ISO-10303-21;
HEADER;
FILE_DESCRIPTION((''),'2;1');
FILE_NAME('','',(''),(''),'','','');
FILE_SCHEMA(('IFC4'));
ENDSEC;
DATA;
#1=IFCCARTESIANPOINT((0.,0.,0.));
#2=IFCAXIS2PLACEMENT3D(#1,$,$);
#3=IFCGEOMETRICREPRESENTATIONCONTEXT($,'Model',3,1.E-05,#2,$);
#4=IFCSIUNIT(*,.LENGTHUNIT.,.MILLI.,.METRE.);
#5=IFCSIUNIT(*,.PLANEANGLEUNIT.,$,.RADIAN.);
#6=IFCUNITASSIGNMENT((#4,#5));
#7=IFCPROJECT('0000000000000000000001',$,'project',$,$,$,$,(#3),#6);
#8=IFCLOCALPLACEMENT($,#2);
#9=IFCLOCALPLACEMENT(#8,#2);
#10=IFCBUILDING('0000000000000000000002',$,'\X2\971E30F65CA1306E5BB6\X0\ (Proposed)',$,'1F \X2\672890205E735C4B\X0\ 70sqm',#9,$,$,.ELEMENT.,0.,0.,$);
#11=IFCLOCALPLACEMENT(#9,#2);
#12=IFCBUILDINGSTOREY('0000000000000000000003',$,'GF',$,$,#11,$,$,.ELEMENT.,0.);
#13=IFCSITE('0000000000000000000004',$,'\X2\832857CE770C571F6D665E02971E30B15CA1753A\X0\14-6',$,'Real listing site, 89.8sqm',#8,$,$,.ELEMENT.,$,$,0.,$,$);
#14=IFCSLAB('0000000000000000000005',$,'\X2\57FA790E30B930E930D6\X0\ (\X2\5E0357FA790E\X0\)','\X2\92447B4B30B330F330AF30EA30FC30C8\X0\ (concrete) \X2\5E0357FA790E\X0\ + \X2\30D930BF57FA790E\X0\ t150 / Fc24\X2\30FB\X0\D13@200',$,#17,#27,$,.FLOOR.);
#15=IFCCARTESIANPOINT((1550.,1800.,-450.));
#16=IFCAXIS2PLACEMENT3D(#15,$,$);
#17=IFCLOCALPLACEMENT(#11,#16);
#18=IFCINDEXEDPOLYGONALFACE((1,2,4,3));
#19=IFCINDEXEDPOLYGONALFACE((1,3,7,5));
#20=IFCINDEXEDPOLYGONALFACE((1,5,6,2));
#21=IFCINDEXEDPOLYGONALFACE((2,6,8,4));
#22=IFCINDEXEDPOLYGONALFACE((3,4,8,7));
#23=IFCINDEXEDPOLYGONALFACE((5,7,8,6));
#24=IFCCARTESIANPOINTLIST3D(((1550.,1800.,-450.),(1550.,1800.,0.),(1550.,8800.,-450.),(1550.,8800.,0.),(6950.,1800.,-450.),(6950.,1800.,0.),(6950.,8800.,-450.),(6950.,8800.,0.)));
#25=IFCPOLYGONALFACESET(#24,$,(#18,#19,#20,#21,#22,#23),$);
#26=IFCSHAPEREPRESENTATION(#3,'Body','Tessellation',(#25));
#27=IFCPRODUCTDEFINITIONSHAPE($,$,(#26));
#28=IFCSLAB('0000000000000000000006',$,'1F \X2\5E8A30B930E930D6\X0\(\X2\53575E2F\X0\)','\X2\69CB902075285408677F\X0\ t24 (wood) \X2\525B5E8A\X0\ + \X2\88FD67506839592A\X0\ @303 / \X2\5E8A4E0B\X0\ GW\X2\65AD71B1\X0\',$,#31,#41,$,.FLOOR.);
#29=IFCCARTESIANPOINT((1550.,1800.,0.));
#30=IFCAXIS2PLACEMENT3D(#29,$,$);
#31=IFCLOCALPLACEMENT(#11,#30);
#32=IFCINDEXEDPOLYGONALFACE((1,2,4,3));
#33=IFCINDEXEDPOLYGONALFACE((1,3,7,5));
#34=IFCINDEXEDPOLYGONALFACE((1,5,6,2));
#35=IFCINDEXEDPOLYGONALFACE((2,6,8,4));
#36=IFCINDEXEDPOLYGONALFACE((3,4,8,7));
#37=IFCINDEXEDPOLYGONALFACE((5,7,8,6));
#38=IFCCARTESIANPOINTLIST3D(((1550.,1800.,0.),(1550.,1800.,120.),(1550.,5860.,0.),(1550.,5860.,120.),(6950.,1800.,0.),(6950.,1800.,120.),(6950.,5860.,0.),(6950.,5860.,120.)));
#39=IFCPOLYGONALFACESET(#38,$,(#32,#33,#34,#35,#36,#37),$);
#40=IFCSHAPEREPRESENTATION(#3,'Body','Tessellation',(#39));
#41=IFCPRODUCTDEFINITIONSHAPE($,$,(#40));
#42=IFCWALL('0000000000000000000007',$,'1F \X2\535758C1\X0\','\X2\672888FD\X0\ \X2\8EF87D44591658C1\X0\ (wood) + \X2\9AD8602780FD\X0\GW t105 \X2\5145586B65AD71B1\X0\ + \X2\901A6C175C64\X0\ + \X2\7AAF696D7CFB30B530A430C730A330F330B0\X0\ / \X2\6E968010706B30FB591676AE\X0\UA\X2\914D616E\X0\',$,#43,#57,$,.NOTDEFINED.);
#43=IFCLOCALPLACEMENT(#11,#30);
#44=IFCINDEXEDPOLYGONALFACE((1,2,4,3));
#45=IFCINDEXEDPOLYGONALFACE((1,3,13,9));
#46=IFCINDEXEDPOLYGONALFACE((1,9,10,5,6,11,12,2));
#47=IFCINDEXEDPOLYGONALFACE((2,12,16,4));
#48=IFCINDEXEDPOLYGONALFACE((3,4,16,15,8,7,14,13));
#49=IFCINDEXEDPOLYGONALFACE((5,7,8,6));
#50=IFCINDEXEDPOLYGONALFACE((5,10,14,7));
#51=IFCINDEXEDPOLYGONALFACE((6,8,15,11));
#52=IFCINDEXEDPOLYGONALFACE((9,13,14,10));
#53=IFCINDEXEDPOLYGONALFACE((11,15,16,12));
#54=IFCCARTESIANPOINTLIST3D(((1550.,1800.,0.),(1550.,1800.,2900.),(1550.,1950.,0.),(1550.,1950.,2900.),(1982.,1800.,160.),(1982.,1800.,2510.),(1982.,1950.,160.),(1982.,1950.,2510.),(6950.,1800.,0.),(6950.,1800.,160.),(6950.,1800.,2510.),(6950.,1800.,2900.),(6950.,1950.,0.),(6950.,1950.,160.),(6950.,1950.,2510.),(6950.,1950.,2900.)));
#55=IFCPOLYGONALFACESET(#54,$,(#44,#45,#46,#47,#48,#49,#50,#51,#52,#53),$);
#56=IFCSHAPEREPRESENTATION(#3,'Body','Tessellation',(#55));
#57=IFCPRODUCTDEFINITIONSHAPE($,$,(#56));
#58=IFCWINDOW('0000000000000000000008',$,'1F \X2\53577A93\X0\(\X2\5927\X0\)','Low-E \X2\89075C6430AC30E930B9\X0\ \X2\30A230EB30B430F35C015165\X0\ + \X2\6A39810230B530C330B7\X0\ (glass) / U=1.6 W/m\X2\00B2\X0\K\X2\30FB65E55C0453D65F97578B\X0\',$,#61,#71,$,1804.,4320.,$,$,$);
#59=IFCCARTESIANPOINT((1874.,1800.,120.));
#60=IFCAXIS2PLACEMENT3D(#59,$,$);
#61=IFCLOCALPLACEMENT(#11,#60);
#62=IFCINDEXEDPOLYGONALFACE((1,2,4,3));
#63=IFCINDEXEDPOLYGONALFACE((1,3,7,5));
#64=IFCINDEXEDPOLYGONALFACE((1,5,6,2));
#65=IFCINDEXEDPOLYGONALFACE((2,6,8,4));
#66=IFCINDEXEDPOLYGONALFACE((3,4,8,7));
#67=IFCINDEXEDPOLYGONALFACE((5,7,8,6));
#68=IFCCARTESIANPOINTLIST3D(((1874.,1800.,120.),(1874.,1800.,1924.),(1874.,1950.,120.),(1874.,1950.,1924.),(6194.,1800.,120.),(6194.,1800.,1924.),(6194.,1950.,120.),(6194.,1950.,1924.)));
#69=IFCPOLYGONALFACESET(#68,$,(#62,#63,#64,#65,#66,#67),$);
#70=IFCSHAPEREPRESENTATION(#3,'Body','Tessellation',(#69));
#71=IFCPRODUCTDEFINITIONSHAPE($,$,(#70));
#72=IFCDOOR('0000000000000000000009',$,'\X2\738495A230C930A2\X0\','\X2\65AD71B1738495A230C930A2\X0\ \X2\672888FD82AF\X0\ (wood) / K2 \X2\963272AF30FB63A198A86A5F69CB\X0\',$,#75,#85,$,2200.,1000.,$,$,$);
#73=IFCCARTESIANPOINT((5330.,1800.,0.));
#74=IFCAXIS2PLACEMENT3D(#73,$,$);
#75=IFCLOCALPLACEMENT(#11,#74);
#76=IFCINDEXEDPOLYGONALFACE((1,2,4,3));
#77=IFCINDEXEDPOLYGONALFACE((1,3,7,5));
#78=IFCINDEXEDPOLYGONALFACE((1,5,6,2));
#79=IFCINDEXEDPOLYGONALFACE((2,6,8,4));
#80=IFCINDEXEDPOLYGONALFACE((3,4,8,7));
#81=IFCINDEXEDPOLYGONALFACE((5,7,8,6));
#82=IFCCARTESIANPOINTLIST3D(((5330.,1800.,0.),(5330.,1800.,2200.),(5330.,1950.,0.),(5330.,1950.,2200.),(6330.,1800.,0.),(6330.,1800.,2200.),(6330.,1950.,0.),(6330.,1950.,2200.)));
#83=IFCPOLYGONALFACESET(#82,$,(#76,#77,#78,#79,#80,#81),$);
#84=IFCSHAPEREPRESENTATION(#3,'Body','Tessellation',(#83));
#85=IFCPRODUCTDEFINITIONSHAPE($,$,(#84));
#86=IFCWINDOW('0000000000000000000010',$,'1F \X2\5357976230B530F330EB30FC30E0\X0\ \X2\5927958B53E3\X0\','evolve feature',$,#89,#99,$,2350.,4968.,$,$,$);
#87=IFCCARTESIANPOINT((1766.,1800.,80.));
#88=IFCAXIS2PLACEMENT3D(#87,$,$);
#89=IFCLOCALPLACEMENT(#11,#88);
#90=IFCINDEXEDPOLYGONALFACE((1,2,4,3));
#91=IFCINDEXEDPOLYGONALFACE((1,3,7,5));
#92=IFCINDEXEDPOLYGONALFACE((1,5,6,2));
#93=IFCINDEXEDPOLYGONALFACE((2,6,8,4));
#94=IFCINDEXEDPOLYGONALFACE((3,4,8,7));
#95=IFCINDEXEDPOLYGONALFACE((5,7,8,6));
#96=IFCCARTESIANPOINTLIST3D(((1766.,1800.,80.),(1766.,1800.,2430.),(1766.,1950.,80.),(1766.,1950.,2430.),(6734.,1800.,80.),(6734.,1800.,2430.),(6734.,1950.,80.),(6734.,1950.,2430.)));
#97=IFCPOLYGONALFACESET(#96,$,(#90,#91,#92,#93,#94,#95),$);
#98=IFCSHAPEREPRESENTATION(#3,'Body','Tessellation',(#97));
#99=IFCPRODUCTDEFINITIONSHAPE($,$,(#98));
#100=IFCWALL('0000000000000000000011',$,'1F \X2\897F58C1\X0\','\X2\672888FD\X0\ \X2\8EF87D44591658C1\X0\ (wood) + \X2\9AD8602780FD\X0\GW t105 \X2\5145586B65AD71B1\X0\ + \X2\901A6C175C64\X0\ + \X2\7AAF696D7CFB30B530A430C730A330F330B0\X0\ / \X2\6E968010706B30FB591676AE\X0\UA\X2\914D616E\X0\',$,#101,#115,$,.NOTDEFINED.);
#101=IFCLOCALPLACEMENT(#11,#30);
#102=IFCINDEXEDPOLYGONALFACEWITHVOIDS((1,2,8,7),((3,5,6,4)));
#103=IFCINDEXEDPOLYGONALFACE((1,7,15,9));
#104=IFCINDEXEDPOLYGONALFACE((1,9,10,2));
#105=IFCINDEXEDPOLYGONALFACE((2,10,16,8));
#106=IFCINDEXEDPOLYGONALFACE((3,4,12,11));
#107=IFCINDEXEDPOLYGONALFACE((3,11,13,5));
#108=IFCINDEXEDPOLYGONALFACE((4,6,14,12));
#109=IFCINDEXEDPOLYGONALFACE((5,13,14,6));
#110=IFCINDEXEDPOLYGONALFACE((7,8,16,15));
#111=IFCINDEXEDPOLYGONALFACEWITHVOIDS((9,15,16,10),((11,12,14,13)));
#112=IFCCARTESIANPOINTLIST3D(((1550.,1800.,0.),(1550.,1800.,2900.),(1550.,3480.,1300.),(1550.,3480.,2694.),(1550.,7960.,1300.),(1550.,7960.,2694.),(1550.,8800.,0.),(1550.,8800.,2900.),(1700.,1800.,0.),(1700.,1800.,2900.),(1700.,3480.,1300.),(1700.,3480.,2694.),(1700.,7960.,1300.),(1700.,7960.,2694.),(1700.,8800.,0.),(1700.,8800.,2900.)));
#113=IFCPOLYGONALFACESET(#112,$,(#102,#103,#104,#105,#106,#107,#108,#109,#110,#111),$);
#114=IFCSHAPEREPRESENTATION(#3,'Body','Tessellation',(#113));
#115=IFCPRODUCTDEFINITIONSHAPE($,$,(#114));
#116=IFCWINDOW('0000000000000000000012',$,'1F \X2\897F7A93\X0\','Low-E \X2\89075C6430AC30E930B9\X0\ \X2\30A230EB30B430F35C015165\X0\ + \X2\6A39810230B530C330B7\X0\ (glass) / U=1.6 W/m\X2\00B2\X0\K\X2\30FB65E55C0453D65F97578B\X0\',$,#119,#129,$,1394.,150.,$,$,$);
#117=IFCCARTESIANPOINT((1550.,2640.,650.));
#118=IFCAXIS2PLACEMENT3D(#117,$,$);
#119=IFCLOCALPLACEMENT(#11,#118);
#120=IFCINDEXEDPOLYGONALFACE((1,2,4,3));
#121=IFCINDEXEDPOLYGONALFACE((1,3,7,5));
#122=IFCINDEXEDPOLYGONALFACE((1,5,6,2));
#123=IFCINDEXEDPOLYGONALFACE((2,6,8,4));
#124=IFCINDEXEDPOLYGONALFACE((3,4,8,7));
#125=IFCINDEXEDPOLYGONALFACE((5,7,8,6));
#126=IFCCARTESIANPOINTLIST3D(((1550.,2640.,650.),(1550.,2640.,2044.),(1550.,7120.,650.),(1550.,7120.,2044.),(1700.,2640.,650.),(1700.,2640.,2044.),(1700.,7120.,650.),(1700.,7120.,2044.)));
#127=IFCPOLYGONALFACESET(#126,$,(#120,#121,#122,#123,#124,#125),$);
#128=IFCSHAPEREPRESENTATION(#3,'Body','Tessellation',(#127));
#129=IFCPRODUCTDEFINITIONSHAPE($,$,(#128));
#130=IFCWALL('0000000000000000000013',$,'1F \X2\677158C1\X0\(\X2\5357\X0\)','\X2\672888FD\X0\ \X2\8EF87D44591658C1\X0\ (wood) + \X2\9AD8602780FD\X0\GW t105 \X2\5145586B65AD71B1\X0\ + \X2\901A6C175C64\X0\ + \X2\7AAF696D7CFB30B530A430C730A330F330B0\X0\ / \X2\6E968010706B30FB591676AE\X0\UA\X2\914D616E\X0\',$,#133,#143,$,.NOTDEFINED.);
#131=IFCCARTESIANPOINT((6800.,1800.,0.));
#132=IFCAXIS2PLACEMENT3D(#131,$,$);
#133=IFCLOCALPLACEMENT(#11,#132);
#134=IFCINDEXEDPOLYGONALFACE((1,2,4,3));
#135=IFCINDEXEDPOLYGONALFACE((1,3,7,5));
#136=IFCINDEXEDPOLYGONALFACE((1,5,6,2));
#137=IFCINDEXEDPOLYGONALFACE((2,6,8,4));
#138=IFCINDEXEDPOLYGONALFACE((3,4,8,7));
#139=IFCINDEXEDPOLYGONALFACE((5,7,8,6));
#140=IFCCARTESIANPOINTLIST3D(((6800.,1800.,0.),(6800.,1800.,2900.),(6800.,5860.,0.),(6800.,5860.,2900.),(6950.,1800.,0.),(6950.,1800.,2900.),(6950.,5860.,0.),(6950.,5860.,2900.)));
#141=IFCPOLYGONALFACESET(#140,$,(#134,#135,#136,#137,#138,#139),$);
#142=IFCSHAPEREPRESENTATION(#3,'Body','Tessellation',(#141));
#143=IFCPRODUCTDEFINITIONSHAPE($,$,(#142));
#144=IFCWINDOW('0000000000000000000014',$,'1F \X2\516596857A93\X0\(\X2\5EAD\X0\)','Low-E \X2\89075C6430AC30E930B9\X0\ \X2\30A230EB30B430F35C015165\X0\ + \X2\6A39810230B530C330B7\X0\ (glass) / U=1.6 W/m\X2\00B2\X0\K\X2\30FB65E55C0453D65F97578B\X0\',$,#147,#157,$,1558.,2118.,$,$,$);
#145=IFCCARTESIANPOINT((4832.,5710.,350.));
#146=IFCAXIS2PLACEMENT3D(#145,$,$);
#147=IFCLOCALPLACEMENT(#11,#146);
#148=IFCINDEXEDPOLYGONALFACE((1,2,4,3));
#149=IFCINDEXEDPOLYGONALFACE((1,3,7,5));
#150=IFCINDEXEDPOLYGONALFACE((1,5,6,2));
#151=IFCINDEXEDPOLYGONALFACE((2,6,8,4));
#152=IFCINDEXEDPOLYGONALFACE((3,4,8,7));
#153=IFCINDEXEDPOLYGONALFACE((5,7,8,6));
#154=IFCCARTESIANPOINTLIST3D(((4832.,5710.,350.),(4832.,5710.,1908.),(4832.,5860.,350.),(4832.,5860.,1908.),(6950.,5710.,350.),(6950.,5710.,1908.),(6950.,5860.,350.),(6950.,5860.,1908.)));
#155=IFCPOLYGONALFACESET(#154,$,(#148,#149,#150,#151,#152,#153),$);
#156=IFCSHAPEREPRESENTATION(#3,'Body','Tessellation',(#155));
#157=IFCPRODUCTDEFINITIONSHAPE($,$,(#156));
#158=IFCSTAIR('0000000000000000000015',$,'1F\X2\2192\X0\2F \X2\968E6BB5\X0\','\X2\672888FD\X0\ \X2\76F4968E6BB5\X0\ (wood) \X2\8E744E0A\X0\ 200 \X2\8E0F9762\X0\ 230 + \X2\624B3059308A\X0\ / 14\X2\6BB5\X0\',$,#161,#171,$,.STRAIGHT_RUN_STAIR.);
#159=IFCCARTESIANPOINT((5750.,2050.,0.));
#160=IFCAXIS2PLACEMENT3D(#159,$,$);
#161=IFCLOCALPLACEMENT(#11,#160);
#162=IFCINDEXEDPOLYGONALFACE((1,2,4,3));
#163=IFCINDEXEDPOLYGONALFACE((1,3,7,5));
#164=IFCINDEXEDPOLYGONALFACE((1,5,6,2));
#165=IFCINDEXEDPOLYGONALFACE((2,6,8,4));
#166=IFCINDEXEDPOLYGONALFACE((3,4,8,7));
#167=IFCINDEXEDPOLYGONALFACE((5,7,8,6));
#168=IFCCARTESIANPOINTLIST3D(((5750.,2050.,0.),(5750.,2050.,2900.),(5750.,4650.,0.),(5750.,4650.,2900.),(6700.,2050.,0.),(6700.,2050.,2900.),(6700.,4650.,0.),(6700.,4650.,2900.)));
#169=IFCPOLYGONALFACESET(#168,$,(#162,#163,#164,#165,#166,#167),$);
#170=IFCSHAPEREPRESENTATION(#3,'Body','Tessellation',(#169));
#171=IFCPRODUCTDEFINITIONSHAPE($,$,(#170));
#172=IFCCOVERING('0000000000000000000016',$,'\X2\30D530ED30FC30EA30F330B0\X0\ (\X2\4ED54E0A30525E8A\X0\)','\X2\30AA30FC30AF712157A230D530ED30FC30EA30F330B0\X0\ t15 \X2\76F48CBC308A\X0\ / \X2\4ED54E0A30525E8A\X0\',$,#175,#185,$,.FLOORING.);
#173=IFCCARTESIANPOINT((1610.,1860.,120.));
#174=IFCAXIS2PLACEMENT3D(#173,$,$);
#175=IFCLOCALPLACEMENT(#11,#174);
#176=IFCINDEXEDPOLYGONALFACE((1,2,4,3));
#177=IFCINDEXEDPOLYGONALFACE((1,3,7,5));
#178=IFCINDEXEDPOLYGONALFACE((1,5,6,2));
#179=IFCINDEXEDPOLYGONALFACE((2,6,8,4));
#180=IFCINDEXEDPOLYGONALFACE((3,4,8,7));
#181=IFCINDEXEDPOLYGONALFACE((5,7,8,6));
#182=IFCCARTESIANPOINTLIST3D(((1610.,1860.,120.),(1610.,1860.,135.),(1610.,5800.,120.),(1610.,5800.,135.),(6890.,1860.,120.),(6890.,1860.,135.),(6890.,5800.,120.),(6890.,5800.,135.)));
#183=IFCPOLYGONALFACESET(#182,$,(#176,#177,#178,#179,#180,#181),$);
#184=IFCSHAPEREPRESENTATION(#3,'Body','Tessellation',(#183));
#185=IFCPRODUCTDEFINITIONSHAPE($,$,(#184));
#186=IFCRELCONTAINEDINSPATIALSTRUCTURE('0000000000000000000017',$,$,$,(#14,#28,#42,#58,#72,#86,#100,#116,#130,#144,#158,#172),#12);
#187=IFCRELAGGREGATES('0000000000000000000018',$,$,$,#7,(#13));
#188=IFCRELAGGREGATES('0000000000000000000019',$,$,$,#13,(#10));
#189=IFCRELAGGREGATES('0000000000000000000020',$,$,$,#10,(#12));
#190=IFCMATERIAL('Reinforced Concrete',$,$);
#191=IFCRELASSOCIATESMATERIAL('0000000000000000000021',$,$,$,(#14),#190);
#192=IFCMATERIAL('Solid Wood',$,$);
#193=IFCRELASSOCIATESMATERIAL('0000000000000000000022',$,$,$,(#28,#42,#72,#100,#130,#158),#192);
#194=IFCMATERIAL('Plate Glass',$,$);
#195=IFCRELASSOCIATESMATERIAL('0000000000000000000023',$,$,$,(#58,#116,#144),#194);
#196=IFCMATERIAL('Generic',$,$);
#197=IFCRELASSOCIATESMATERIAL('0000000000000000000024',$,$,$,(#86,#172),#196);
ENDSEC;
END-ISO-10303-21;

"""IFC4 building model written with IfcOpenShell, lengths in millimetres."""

from ifc_helpers import new_model, si_unit, frame, frame_2d, origin, place, context, project, spatial, rectangle, extrude, material, element, fill, save


model = new_model("IFC4")

# Units and contexts
model_context = context("Model", 3, precision=1e-05, world=origin())
ifc_project = project(units=[si_unit("LENGTHUNIT", "METRE", prefix="MILLI"), si_unit("PLANEANGLEUNIT", "RADIAN")], contexts=[model_context])

# Site, building, storey
site_placement = place(None, origin())
site = spatial("IfcSite", under=ifc_project, at=site_placement, Name="茨城県土浦市霞ケ岡町14-6", ObjectType="Real listing site, 89.8sqm", CompositionType="ELEMENT", RefElevation=0.0)
building_placement = place(site_placement, origin())
building = spatial("IfcBuilding", under=site, at=building_placement, Name="霞ヶ岡の家 (Proposed)", ObjectType="1F 木造平屋 70sqm", CompositionType="ELEMENT", ElevationOfRefHeight=0.0, ElevationOfTerrain=0.0)
storey_placement = place(building_placement, origin())
storey = spatial("IfcBuildingStorey", under=building, at=storey_placement, Name="GF", CompositionType="ELEMENT", Elevation=0.0)

# Slabs
ifc_material_1 = material(Name="Reinforced Concrete")
slab_1_placement = place(storey_placement, frame((1550.0, 1800.0, -450.0)))
element("IfcSlab", 1, at=slab_1_placement, inside=storey, material=ifc_material_1, Name="基礎スラブ (布基礎)", Description="鉄筋コンクリート (concrete) 布基礎 + ベタ基礎 t150 / Fc24・D13@200", PredefinedType="FLOOR", context=model_context, shape_type="SweptSolid", body=[
    extrude(rectangle(XDim=5400.0, YDim=7000.0, at=frame_2d((2700.0, 3500.0))), frame((1550.0, 1800.0, -450.0)), (0.0, 0.0, 1.0), 450.0),
])
ifc_material_2 = material(Name="Solid Wood")
slab_2_placement = place(storey_placement, frame((1550.0, 1800.0, 0.0)))
element("IfcSlab", 2, at=slab_2_placement, inside=storey, material=ifc_material_2, Name="1F 床スラブ(南帯)", Description="構造用合板 t24 (wood) 剛床 + 製材根太 @303 / 床下 GW断熱", PredefinedType="FLOOR", context=model_context, shape_type="SweptSolid", body=[
    extrude(rectangle(XDim=5400.0, YDim=4060.0, at=frame_2d((2700.0, 2030.0))), frame((1550.0, 1800.0, 0.0)), (0.0, 0.0, 1.0), 120.0),
])

# Wall, openings, windows, door
wall_1_placement = place(storey_placement, frame((1550.0, 1800.0, 0.0)))
wall_1 = element("IfcWall", 3, at=wall_1_placement, inside=storey, material=ifc_material_2, Name="1F 南壁", Description="木製 軸組外壁 (wood) + 高性能GW t105 充填断熱 + 通気層 + 窯業系サイディング / 準耐火・外皮UA配慮", PredefinedType="NOTDEFINED", context=model_context, shape_type="SweptSolid", body=[
    extrude(rectangle(XDim=5400.0, YDim=150.0, at=frame_2d((2700.0, 75.0))), frame((1550.0, 1800.0, 0.0)), (0.0, 0.0, 1.0), 2900.0),
])
opening_1_placement = place(storey_placement, frame((1874.0, 1800.0, 120.0)))
opening_1 = element("IfcOpeningElement", 4, at=opening_1_placement, cuts=wall_1, PredefinedType="NOTDEFINED", context=model_context, shape_type="SweptSolid", body=[
    extrude(rectangle(XDim=4320.0, YDim=150.0, at=frame_2d((2160.0, 75.0))), frame((1874.0, 1800.0, 120.0)), (0.0, 0.0, 1.0), 1804.0),
])
opening_2_placement = place(storey_placement, frame((5330.0, 1800.0, 0.0)))
opening_2 = element("IfcOpeningElement", 5, at=opening_2_placement, cuts=wall_1, PredefinedType="NOTDEFINED", context=model_context, shape_type="SweptSolid", body=[
    extrude(rectangle(XDim=1000.0, YDim=150.0, at=frame_2d((500.0, 75.0))), frame((5330.0, 1800.0, 0.0)), (0.0, 0.0, 1.0), 2200.0),
])
opening_3_placement = place(storey_placement, frame((1766.0, 1800.0, 80.0)))
opening_3 = element("IfcOpeningElement", 6, at=opening_3_placement, cuts=wall_1, PredefinedType="NOTDEFINED", context=model_context, shape_type="SweptSolid", body=[
    extrude(rectangle(XDim=4968.0, YDim=150.0, at=frame_2d((2484.0, 75.0))), frame((1766.0, 1800.0, 80.0)), (0.0, 0.0, 1.0), 2350.0),
])
ifc_material_3 = material(Name="Plate Glass")
window_1_placement = place(storey_placement, frame((1874.0, 1800.0, 120.0)))
window_1 = element("IfcWindow", 7, at=window_1_placement, inside=storey, material=ifc_material_3, Name="1F 南窓(大)", Description="Low-E 複層ガラス アルゴン封入 + 樹脂サッシ (glass) / U=1.6 W/m²K・日射取得型", OverallHeight=1804.0, OverallWidth=4320.0, context=model_context, shape_type="SweptSolid", body=[
    extrude(rectangle(XDim=4320.0, YDim=150.0, at=frame_2d((2160.0, 75.0))), frame((1874.0, 1800.0, 120.0)), (0.0, 0.0, 1.0), 1804.0),
])
fill(opening_1, window_1)
door_1_placement = place(storey_placement, frame((5330.0, 1800.0, 0.0)))
door_1 = element("IfcDoor", 8, at=door_1_placement, inside=storey, material=ifc_material_2, Name="玄関ドア", Description="断熱玄関ドア 木製芯 (wood) / K2 防犯・採風機構", OverallHeight=2200.0, OverallWidth=1000.0, context=model_context, shape_type="SweptSolid", body=[
    extrude(rectangle(XDim=1000.0, YDim=150.0, at=frame_2d((500.0, 75.0))), frame((5330.0, 1800.0, 0.0)), (0.0, 0.0, 1.0), 2200.0),
])
fill(opening_2, door_1)
ifc_material_4 = material(Name="Generic")
window_2_placement = place(storey_placement, frame((1766.0, 1800.0, 80.0)))
window_2 = element("IfcWindow", 9, at=window_2_placement, inside=storey, material=ifc_material_4, Name="1F 南面サンルーム 大開口", Description="evolve feature", OverallHeight=2350.0, OverallWidth=4968.0, context=model_context, shape_type="SweptSolid", body=[
    extrude(rectangle(XDim=4968.0, YDim=150.0, at=frame_2d((2484.0, 75.0))), frame((1766.0, 1800.0, 80.0)), (0.0, 0.0, 1.0), 2350.0),
])
fill(opening_3, window_2)

# Walls, openings, windows
wall_2_placement = place(storey_placement, frame((1550.0, 1800.0, 0.0)))
wall_2 = element("IfcWall", 10, at=wall_2_placement, inside=storey, material=ifc_material_2, Name="1F 西壁", Description="木製 軸組外壁 (wood) + 高性能GW t105 充填断熱 + 通気層 + 窯業系サイディング / 準耐火・外皮UA配慮", PredefinedType="NOTDEFINED", context=model_context, shape_type="SweptSolid", body=[
    extrude(rectangle(XDim=150.0, YDim=7000.0, at=frame_2d((75.0, 3500.0))), frame((1550.0, 1800.0, 0.0)), (0.0, 0.0, 1.0), 2900.0),
])
opening_4_placement = place(storey_placement, frame((1550.0, 2640.0, 650.0)))
opening_4 = element("IfcOpeningElement", 11, at=opening_4_placement, cuts=wall_2, PredefinedType="NOTDEFINED", context=model_context, shape_type="SweptSolid", body=[
    extrude(rectangle(XDim=150.0, YDim=4480.0, at=frame_2d((75.0, 2240.0))), frame((1550.0, 2640.0, 650.0)), (0.0, 0.0, 1.0), 1394.0),
])
window_3_placement = place(storey_placement, frame((1550.0, 2640.0, 650.0)))
window_3 = element("IfcWindow", 12, at=window_3_placement, inside=storey, material=ifc_material_3, Name="1F 西窓", Description="Low-E 複層ガラス アルゴン封入 + 樹脂サッシ (glass) / U=1.6 W/m²K・日射取得型", OverallHeight=1394.0, OverallWidth=150.0, context=model_context, shape_type="SweptSolid", body=[
    extrude(rectangle(XDim=150.0, YDim=4480.0, at=frame_2d((75.0, 2240.0))), frame((1550.0, 2640.0, 650.0)), (0.0, 0.0, 1.0), 1394.0),
])
fill(opening_4, window_3)
wall_3_placement = place(storey_placement, frame((6800.0, 1800.0, 0.0)))
wall_3 = element("IfcWall", 13, at=wall_3_placement, inside=storey, material=ifc_material_2, Name="1F 東壁(南)", Description="木製 軸組外壁 (wood) + 高性能GW t105 充填断熱 + 通気層 + 窯業系サイディング / 準耐火・外皮UA配慮", PredefinedType="NOTDEFINED", context=model_context, shape_type="SweptSolid", body=[
    extrude(rectangle(XDim=150.0, YDim=4060.0, at=frame_2d((75.0, 2030.0))), frame((6800.0, 1800.0, 0.0)), (0.0, 0.0, 1.0), 2900.0),
])
opening_5_placement = place(storey_placement, frame((4832.0, 5710.0, 350.0)))
opening_5 = element("IfcOpeningElement", 14, at=opening_5_placement, cuts=wall_3, PredefinedType="NOTDEFINED", context=model_context, shape_type="SweptSolid", body=[
    extrude(rectangle(XDim=2118.0, YDim=150.0, at=frame_2d((1059.0, 75.0))), frame((4832.0, 5710.0, 350.0)), (0.0, 0.0, 1.0), 1558.0),
])
window_4_placement = place(storey_placement, frame((4832.0, 5710.0, 350.0)))
window_4 = element("IfcWindow", 15, at=window_4_placement, inside=storey, material=ifc_material_3, Name="1F 入隅窓(庭)", Description="Low-E 複層ガラス アルゴン封入 + 樹脂サッシ (glass) / U=1.6 W/m²K・日射取得型", OverallHeight=1558.0, OverallWidth=2118.0, context=model_context, shape_type="SweptSolid", body=[
    extrude(rectangle(XDim=2118.0, YDim=150.0, at=frame_2d((1059.0, 75.0))), frame((4832.0, 5710.0, 350.0)), (0.0, 0.0, 1.0), 1558.0),
])
fill(opening_5, window_4)

# Stair
stair_placement = place(storey_placement, frame((5750.0, 2050.0, 0.0)))
element("IfcStair", 16, at=stair_placement, inside=storey, material=ifc_material_2, Name="1F→2F 階段", Description="木製 直階段 (wood) 蹴上 200 踏面 230 + 手すり / 14段", PredefinedType="STRAIGHT_RUN_STAIR", context=model_context, shape_type="SweptSolid", body=[
    extrude(rectangle(XDim=950.0, YDim=2600.0, at=frame_2d((475.0, 1300.0))), frame((5750.0, 2050.0, 0.0)), (0.0, 0.0, 1.0), 2900.0),
])

# Covering
covering_placement = place(storey_placement, frame((1610.0, 1860.0, 120.0)))
element("IfcCovering", 17, at=covering_placement, inside=storey, material=ifc_material_4, Name="フローリング (仕上げ床)", Description="オーク無垢フローリング t15 直貼り / 仕上げ床", PredefinedType="FLOORING", context=model_context, shape_type="SweptSolid", body=[
    extrude(rectangle(XDim=5280.0, YDim=3940.0, at=frame_2d((2640.0, 1970.0))), frame((1610.0, 1860.0, 120.0)), (0.0, 0.0, 1.0), 15.0),
])

save(model, "model.ifc")
